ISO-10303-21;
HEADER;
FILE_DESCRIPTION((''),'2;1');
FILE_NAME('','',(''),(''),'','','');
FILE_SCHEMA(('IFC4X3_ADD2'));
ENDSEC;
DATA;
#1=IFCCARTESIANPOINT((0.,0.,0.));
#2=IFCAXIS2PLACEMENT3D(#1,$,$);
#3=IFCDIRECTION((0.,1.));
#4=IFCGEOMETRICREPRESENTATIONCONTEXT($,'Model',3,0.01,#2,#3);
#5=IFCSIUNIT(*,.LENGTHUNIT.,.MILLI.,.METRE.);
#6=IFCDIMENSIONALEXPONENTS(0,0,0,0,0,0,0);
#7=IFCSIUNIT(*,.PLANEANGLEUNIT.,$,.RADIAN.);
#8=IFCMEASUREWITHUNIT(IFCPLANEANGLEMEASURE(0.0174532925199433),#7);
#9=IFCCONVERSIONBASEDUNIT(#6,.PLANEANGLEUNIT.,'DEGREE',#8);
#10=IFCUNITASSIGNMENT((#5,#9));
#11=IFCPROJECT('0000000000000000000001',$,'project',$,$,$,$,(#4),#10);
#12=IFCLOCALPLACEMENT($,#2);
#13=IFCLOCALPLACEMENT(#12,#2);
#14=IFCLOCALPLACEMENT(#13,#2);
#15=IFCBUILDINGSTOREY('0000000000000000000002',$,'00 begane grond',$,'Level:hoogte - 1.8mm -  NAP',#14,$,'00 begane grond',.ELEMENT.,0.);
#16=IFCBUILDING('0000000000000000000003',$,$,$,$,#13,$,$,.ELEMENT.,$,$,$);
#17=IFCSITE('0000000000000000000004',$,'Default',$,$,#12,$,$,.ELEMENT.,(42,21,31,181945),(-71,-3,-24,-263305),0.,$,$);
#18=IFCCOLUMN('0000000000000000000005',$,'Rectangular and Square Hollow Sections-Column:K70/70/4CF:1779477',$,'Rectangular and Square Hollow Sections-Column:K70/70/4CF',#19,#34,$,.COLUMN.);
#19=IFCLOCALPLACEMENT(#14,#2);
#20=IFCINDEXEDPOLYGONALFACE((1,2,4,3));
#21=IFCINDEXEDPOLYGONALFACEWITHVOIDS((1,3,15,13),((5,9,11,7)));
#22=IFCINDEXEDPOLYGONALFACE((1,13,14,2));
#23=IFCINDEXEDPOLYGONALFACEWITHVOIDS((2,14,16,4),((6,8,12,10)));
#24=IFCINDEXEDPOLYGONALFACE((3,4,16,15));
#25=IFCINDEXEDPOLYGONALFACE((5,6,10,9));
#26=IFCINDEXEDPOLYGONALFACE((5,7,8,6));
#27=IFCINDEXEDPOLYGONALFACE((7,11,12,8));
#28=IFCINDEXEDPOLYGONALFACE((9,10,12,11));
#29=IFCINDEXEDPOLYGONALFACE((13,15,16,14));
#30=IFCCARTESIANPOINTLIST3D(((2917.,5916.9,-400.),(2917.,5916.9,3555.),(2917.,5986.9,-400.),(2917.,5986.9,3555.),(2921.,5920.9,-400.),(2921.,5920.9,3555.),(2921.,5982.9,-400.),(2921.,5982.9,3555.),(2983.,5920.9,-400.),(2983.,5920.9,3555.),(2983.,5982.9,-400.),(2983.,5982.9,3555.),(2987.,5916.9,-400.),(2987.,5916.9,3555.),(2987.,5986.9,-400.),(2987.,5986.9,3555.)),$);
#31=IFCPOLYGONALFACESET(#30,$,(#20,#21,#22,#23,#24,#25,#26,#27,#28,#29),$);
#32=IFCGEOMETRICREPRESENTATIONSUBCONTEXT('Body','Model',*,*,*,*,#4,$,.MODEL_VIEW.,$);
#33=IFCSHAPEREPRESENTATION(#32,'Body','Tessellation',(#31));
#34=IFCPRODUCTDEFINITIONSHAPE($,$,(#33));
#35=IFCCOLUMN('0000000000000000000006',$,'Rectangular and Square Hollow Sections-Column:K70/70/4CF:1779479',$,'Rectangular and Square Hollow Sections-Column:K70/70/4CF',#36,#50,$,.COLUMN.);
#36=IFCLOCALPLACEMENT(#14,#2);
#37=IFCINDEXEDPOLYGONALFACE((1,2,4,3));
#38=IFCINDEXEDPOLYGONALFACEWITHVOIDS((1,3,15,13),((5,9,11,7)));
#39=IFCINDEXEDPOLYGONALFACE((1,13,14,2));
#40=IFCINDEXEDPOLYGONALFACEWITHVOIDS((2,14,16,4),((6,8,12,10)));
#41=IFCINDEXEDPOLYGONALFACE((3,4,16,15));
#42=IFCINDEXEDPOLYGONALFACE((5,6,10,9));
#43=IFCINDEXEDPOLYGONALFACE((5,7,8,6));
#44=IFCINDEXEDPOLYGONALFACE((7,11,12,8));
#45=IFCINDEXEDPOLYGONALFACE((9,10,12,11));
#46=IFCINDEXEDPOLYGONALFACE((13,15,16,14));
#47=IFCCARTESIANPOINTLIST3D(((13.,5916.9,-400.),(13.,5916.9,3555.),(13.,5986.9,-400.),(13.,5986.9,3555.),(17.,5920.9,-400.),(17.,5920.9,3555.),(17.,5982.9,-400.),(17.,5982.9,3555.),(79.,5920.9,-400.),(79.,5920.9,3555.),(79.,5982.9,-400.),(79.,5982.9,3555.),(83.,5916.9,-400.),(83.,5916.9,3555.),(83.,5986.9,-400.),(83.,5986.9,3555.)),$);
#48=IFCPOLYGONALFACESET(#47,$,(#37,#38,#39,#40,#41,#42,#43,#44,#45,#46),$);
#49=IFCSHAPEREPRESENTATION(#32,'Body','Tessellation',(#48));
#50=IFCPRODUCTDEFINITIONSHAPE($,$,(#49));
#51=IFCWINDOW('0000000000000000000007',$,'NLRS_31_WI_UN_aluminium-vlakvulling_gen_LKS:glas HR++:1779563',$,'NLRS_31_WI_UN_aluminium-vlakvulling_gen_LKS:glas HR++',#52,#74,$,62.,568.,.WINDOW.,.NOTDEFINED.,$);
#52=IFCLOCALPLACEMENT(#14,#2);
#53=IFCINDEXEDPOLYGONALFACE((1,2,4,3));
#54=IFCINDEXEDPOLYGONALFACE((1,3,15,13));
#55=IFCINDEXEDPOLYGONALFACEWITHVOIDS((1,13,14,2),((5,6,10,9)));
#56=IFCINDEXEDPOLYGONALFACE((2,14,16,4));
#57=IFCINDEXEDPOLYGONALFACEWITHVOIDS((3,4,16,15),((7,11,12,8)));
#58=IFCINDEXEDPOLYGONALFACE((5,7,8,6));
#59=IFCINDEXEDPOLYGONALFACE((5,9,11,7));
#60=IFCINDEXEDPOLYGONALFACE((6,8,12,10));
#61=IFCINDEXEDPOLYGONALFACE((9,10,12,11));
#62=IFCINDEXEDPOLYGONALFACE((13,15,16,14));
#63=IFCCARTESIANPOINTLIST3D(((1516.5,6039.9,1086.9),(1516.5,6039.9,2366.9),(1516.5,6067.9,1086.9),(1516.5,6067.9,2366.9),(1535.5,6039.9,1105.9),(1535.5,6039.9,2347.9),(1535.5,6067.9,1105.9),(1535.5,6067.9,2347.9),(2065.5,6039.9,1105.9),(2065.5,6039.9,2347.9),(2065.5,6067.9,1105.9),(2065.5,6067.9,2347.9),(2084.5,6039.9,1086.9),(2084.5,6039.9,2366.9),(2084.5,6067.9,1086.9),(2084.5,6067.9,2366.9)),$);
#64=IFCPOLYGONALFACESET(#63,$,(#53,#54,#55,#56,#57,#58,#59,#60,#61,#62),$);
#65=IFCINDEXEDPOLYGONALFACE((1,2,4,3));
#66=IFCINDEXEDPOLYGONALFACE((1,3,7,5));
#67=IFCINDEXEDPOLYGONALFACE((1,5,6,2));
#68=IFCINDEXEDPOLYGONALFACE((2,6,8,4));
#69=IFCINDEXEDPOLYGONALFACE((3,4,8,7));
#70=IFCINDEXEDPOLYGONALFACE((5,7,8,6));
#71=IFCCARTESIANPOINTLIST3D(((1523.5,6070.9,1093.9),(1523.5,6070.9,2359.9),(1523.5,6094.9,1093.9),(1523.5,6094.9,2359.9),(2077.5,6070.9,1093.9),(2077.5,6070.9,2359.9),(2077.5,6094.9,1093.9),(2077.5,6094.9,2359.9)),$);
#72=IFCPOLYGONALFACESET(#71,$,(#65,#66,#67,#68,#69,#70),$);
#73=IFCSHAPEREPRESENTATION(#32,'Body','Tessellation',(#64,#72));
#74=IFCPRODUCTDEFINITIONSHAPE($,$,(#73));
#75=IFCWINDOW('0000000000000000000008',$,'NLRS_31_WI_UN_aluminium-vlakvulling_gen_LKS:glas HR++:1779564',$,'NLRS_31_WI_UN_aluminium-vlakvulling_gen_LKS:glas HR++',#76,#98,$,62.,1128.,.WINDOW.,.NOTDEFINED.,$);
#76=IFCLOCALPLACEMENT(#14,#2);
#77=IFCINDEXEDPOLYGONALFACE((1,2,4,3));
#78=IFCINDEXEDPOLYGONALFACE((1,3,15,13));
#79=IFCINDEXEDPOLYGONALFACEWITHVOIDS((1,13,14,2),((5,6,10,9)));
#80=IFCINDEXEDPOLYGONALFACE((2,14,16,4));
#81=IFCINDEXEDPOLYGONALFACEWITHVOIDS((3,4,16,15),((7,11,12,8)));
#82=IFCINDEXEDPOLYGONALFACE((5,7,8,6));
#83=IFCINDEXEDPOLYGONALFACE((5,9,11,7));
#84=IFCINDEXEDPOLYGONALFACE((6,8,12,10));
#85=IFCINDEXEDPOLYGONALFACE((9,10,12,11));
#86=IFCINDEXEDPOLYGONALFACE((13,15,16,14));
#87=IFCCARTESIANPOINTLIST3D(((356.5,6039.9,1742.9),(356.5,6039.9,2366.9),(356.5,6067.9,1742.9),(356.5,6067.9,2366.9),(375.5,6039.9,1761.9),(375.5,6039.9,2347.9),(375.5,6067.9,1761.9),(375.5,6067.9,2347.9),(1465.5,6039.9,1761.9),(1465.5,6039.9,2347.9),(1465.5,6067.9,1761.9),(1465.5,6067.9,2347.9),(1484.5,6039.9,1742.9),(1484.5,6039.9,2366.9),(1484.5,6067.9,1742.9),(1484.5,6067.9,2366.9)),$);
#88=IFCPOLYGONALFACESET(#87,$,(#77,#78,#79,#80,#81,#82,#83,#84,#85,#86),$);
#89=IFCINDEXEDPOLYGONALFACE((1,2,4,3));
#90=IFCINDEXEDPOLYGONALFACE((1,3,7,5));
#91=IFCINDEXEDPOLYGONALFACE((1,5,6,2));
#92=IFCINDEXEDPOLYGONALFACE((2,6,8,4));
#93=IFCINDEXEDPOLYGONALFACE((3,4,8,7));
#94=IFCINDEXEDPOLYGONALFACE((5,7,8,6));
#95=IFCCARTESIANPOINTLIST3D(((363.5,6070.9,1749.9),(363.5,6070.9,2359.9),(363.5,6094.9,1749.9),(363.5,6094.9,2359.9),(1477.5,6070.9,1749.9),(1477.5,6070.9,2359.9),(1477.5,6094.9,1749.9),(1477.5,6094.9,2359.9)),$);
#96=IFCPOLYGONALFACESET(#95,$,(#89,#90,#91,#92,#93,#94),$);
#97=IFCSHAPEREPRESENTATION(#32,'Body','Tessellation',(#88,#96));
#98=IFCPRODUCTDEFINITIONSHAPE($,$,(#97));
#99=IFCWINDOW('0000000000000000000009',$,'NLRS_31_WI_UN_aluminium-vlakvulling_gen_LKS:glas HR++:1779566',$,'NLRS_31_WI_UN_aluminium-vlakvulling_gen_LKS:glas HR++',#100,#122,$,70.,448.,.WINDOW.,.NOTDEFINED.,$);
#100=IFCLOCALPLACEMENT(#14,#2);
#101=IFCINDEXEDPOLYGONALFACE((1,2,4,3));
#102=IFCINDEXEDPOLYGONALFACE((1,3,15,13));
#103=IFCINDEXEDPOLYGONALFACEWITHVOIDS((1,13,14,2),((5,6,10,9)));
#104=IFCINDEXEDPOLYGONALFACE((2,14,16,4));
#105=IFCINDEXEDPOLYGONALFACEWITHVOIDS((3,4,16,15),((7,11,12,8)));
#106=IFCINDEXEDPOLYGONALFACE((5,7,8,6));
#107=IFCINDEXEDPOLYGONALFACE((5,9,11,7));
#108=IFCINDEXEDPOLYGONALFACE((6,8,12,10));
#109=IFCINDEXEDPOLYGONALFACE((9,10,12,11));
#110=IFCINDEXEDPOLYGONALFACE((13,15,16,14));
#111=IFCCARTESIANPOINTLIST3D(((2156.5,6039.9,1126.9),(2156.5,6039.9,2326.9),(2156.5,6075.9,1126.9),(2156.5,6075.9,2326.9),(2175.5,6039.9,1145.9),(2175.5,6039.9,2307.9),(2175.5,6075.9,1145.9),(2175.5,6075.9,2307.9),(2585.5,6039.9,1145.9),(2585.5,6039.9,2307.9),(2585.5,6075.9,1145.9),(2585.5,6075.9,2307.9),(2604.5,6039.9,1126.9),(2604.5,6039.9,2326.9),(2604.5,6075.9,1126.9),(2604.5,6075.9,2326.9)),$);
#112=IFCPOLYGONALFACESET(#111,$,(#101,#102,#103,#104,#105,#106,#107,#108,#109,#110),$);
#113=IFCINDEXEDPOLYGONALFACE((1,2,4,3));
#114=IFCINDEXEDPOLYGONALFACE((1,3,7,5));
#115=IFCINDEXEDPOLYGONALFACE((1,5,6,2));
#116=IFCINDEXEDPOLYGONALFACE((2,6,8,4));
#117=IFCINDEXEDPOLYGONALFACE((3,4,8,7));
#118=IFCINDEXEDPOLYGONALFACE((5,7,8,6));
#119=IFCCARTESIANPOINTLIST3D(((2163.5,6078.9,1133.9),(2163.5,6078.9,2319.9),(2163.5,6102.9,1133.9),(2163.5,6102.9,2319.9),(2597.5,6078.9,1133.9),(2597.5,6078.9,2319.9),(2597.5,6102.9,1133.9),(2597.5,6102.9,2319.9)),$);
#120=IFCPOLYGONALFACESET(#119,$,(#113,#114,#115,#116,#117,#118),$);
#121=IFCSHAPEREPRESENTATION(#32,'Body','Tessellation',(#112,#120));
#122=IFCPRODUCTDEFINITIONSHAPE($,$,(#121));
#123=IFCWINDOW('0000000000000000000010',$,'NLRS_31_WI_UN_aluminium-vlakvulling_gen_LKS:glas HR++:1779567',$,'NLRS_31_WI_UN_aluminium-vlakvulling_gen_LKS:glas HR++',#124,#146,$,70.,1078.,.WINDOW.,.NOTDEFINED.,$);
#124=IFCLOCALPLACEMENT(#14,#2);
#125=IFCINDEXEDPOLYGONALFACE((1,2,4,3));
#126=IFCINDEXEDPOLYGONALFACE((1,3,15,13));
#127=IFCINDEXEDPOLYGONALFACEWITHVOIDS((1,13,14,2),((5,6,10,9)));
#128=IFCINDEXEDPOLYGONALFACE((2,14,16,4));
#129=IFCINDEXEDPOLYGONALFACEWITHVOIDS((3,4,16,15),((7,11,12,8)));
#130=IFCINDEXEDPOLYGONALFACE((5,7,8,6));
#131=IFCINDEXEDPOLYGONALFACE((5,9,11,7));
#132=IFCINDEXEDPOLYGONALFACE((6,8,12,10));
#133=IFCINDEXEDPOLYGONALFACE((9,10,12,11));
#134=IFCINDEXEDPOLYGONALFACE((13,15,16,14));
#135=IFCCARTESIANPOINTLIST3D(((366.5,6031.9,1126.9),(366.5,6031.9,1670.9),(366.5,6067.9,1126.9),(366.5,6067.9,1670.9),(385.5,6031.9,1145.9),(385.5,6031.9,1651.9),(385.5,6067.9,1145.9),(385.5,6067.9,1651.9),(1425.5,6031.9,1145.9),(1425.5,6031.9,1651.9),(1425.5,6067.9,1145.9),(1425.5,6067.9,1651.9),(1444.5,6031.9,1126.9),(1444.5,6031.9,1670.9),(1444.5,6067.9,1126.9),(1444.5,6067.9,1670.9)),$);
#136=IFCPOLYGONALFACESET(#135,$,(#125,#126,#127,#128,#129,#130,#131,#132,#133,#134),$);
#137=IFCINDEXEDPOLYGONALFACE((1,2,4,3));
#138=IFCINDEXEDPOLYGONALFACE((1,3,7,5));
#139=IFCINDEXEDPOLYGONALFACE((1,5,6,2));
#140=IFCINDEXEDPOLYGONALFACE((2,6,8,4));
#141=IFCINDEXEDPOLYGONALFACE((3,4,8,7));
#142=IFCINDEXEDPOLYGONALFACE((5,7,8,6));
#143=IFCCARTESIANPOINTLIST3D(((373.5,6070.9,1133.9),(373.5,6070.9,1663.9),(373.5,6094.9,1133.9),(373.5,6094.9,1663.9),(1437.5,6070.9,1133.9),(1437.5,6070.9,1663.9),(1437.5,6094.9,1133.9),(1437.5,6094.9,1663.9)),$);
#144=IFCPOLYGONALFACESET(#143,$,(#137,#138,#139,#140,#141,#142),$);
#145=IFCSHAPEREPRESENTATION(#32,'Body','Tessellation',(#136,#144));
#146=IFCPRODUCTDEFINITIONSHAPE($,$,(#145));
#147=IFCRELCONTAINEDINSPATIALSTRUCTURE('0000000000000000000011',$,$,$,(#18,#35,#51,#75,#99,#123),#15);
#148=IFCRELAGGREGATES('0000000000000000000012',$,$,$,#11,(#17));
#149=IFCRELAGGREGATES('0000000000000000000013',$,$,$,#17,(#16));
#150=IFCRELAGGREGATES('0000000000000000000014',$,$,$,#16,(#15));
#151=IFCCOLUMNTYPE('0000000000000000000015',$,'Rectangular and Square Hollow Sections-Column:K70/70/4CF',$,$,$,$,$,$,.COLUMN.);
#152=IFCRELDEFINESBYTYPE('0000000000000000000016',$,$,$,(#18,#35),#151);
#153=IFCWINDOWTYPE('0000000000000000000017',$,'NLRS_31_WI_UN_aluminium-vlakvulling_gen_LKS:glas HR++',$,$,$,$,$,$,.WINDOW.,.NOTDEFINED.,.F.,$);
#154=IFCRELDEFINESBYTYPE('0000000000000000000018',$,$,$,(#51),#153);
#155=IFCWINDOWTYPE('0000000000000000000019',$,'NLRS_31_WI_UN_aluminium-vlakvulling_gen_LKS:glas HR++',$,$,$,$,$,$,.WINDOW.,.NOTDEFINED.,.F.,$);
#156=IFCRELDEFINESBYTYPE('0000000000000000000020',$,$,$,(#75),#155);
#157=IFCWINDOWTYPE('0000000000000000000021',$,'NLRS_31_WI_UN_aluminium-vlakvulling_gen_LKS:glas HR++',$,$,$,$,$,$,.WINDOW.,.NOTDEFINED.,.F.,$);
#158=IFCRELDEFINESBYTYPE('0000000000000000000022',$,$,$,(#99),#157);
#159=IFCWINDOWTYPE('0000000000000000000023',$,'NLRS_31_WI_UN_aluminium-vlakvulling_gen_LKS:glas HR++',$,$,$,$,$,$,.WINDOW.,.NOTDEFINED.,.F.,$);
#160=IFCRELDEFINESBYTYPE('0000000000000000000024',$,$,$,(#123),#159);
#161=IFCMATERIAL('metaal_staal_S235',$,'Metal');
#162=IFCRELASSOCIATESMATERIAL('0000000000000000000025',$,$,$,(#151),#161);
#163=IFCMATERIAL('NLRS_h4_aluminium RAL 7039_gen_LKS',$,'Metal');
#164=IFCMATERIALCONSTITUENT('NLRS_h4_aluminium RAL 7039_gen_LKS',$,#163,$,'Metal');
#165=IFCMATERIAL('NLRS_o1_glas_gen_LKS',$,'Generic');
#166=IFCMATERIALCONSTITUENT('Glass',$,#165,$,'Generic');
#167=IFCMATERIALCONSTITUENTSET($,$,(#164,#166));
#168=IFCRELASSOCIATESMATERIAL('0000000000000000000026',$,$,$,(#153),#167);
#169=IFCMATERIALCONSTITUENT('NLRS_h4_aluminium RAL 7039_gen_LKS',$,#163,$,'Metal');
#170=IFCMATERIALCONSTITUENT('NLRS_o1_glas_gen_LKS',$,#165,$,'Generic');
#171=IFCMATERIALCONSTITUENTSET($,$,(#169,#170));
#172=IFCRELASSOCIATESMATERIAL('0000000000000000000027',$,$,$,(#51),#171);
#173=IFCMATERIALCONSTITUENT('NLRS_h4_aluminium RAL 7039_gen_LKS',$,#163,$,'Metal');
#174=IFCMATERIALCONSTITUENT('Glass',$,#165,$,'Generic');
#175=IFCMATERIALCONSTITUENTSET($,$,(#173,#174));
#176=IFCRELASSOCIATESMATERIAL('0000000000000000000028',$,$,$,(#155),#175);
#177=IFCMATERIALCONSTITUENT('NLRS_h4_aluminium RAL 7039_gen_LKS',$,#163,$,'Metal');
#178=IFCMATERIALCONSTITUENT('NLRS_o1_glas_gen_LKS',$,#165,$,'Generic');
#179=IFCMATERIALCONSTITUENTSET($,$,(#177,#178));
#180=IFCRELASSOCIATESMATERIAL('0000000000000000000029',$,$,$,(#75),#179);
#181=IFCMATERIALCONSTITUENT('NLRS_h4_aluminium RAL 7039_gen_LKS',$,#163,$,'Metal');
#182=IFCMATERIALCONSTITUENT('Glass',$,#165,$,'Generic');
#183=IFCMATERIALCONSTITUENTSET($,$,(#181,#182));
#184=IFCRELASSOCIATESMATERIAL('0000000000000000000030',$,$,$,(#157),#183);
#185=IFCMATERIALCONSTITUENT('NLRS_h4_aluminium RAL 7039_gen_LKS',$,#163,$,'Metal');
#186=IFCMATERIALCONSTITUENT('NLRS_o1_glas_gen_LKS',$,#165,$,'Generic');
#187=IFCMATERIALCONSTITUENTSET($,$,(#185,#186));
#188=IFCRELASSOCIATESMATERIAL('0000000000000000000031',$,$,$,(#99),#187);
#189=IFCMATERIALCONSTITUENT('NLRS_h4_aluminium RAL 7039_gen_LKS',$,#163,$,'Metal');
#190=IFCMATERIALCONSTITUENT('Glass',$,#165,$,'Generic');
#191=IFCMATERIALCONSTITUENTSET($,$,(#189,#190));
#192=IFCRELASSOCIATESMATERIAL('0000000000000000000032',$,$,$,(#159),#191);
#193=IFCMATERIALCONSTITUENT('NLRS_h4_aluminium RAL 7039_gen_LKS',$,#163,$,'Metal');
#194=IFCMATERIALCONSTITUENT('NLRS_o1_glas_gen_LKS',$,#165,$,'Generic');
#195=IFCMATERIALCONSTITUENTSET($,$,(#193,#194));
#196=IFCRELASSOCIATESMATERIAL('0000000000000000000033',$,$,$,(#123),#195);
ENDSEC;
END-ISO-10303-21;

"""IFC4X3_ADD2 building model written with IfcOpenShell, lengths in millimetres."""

from ifc_helpers import new_model, entity, si_unit, converted_unit, direction, frame, frame_2d, origin, origin_2d_with_axis, place, context, subcontext, project, spatial, polyline, rectangle, outline, extrude, source, transform, mapped, material, constituent, constituent_set, material_profile, profile_set, type_object, type_shapes, element, save


model = new_model("IFC4X3_ADD2")

# Units and contexts
model_context = context("Model", 3, precision=0.01, world=origin(), true_north=direction((0.0, 1.0)))
body_context = subcontext(model_context, "Body", "Model", "MODEL_VIEW")
ifc_project = project(units=[si_unit("LENGTHUNIT", "METRE", prefix="MILLI"), converted_unit("PLANEANGLEUNIT", "DEGREE", entity("IfcPlaneAngleMeasure", 0.0174532925199433), si_unit("PLANEANGLEUNIT", "RADIAN"), dimensions=[0, 0, 0, 0, 0, 0, 0])], contexts=[model_context])

# Site, building, storey
site_placement = place(None, origin())
site = spatial("IfcSite", under=ifc_project, at=site_placement, Name="Default", CompositionType="ELEMENT", RefLatitude=(42, 21, 31, 181945), RefLongitude=(-71, -3, -24, -263305), RefElevation=0.0)
building_placement = place(site_placement, origin())
building = spatial("IfcBuilding", under=site, at=building_placement, CompositionType="ELEMENT")
storey_placement = place(building_placement, origin())
storey = spatial("IfcBuildingStorey", under=building, at=storey_placement, Name="00 begane grond", ObjectType="Level:hoogte - 1.8mm -  NAP", LongName="00 begane grond", CompositionType="ELEMENT", Elevation=0.0)

# Columns
ifc_material_1 = material(Name="metaal_staal_S235", Category="Metal")
ifc_material_profile_1 = material_profile(ifc_material_1, outline(polyline([(-35.0, -35.0), (35.0, -35.0), (35.0, 35.0), (-35.0, 35.0), (-35.0, -35.0)]), holes=[polyline([(-31.0, -31.0), (-31.0, 31.0), (31.0, 31.0), (31.0, -31.0), (-31.0, -31.0)])]), Name="K70/70/4CF")
ifc_profile_set_1 = profile_set([ifc_material_profile_1], Name="K70/70/4CF")
column_type = type_object("IfcColumnType", Name="Rectangular and Square Hollow Sections-Column:K70/70/4CF", PredefinedType="COLUMN", material=ifc_profile_set_1)
shared_shape_1 = source(origin(), body_context, "Body", "SweptSolid", [
    extrude(outline(polyline([(-35.0, -35.0), (35.0, -35.0), (35.0, 35.0), (-35.0, 35.0), (-35.0, -35.0)]), holes=[polyline([(-31.0, -31.0), (-31.0, 31.0), (31.0, 31.0), (31.0, -31.0), (-31.0, -31.0)])]), frame((0.0, 0.0, -400.0), z_axis=(0.0, 0.0, 1.0), x_axis=(0.0, 1.0, 0.0)), (0.0, 0.0, 1.0), 3955.0),
])
type_shapes(column_type, [shared_shape_1])
for number, where, z_axis, x_axis, name in (
    (1, (2952.0, 5951.9, 0.0), (0.0, 0.0, 1.0), (0.0, 1.0, 0.0), "Rectangular and Square Hollow Sections-Column:K70/70/4CF:1779477"),
    (2, (48.0, 5951.9, 0.0), (0.0, 0.0, 1.0), (0.0, 1.0, 0.0), "Rectangular and Square Hollow Sections-Column:K70/70/4CF:1779479"),
):
    element("IfcColumn", number, at=place(storey_placement, frame(where, z_axis=z_axis, x_axis=x_axis)), inside=storey, type_object=column_type, Name=name, ObjectType="Rectangular and Square Hollow Sections-Column:K70/70/4CF", PredefinedType="COLUMN", context=body_context, shape_type="MappedRepresentation", body=[
        mapped(shared_shape_1, transform((0.0, 0.0, 0.0), scale=1.0)),
    ])

# Windows
ifc_material_2 = material(Name="NLRS_h4_aluminium RAL 7039_gen_LKS", Category="Metal")
ifc_constituent_1 = constituent(ifc_material_2, Name="NLRS_h4_aluminium RAL 7039_gen_LKS", Category="Metal")
ifc_material_3 = material(Name="NLRS_o1_glas_gen_LKS", Category="Generic")
ifc_constituent_2 = constituent(ifc_material_3, Name="NLRS_o1_glas_gen_LKS", Category="Generic")
ifc_constituent_set_1 = constituent_set(constituents=[ifc_constituent_1, ifc_constituent_2])
ifc_constituent_3 = constituent(ifc_material_2, Name="NLRS_h4_aluminium RAL 7039_gen_LKS", Category="Metal")
ifc_constituent_4 = constituent(ifc_material_3, Name="Glass", Category="Generic")
ifc_constituent_set_2 = constituent_set(constituents=[ifc_constituent_3, ifc_constituent_4])
window_type_1 = type_object("IfcWindowType", Name="NLRS_31_WI_UN_aluminium-vlakvulling_gen_LKS:glas HR++", ParameterTakesPrecedence=False, PartitioningType="NOTDEFINED", PredefinedType="WINDOW", material=ifc_constituent_set_2)
shared_shape_2 = source(origin(), body_context, "Body", "SweptSolid", [
    extrude(outline(polyline([(-640.0, -284.0), (640.0, -284.0), (640.0, 284.0), (-640.0, 284.0), (-640.0, -284.0)]), holes=[polyline([(621.0, -265.0), (-621.0, -265.0), (-621.0, 265.0), (621.0, 265.0), (621.0, -265.0)])]), frame((0.0, 34.0, 640.0), z_axis=(0.0, 1.0, 0.0), x_axis=(0.0, 0.0, -1.0)), (0.0, 0.0, 1.0), 28.0),
    extrude(rectangle(XDim=24.0, YDim=554.0, at=frame_2d((0.0, 0.0), x_axis=(1.0, 0.0))), frame((0.0, 19.0, 7.0), z_axis=(0.0, 0.0, 1.0), x_axis=(0.0, -1.0, 0.0)), (0.0, 0.0, 1.0), 1266.0),
])
type_shapes(window_type_1, [shared_shape_2])
window_1_placement = place(storey_placement, frame((1800.5, 6101.9, 1086.9), z_axis=(0.0, 0.0, 1.0), x_axis=(-1.0, 0.0, 0.0)))
element("IfcWindow", 3, at=window_1_placement, inside=storey, type_object=window_type_1, material=ifc_constituent_set_1, Name="NLRS_31_WI_UN_aluminium-vlakvulling_gen_LKS:glas HR++:1779563", ObjectType="NLRS_31_WI_UN_aluminium-vlakvulling_gen_LKS:glas HR++", OverallHeight=62.0, OverallWidth=568.0, PartitioningType="NOTDEFINED", PredefinedType="WINDOW", context=body_context, shape_type="MappedRepresentation", body=[
    mapped(shared_shape_2, transform((0.0, 0.0, 0.0), scale=1.0)),
])
ifc_constituent_5 = constituent(ifc_material_2, Name="NLRS_h4_aluminium RAL 7039_gen_LKS", Category="Metal")
ifc_constituent_6 = constituent(ifc_material_3, Name="NLRS_o1_glas_gen_LKS", Category="Generic")
ifc_constituent_set_3 = constituent_set(constituents=[ifc_constituent_5, ifc_constituent_6])
ifc_constituent_7 = constituent(ifc_material_2, Name="NLRS_h4_aluminium RAL 7039_gen_LKS", Category="Metal")
ifc_constituent_8 = constituent(ifc_material_3, Name="Glass", Category="Generic")
ifc_constituent_set_4 = constituent_set(constituents=[ifc_constituent_7, ifc_constituent_8])
window_type_2 = type_object("IfcWindowType", Name="NLRS_31_WI_UN_aluminium-vlakvulling_gen_LKS:glas HR++", ParameterTakesPrecedence=False, PartitioningType="NOTDEFINED", PredefinedType="WINDOW", material=ifc_constituent_set_4)
shared_shape_3 = source(origin(), body_context, "Body", "SweptSolid", [
    extrude(outline(polyline([(-312.0, -564.0), (312.0, -564.0), (312.0, 564.0), (-312.0, 564.0), (-312.0, -564.0)]), holes=[polyline([(293.0, -545.0), (-293.0, -545.0), (-293.0, 545.0), (293.0, 545.0), (293.0, -545.0)])]), frame((0.0, 34.0, 312.0), z_axis=(0.0, 1.0, 0.0), x_axis=(0.0, 0.0, -1.0)), (0.0, 0.0, 1.0), 28.0),
    extrude(rectangle(XDim=24.0, YDim=1114.0, at=frame_2d((0.0, 0.0), x_axis=(1.0, 0.0))), frame((0.0, 19.0, 7.0), z_axis=(0.0, 0.0, 1.0), x_axis=(0.0, -1.0, 0.0)), (0.0, 0.0, 1.0), 610.0),
])
type_shapes(window_type_2, [shared_shape_3])
window_2_placement = place(storey_placement, frame((920.5, 6101.9, 1742.9), z_axis=(0.0, 0.0, 1.0), x_axis=(-1.0, 0.0, 0.0)))
element("IfcWindow", 4, at=window_2_placement, inside=storey, type_object=window_type_2, material=ifc_constituent_set_3, Name="NLRS_31_WI_UN_aluminium-vlakvulling_gen_LKS:glas HR++:1779564", ObjectType="NLRS_31_WI_UN_aluminium-vlakvulling_gen_LKS:glas HR++", OverallHeight=62.0, OverallWidth=1128.0, PartitioningType="NOTDEFINED", PredefinedType="WINDOW", context=body_context, shape_type="MappedRepresentation", body=[
    mapped(shared_shape_3, transform((0.0, 0.0, 0.0), scale=1.0)),
])
ifc_constituent_9 = constituent(ifc_material_2, Name="NLRS_h4_aluminium RAL 7039_gen_LKS", Category="Metal")
ifc_constituent_10 = constituent(ifc_material_3, Name="NLRS_o1_glas_gen_LKS", Category="Generic")
ifc_constituent_set_5 = constituent_set(constituents=[ifc_constituent_9, ifc_constituent_10])
ifc_constituent_11 = constituent(ifc_material_2, Name="NLRS_h4_aluminium RAL 7039_gen_LKS", Category="Metal")
ifc_constituent_12 = constituent(ifc_material_3, Name="Glass", Category="Generic")
ifc_constituent_set_6 = constituent_set(constituents=[ifc_constituent_11, ifc_constituent_12])
window_type_3 = type_object("IfcWindowType", Name="NLRS_31_WI_UN_aluminium-vlakvulling_gen_LKS:glas HR++", ParameterTakesPrecedence=False, PartitioningType="NOTDEFINED", PredefinedType="WINDOW", material=ifc_constituent_set_6)
shared_shape_4 = source(origin(), body_context, "Body", "SweptSolid", [
    extrude(outline(polyline([(-600.0, -224.0), (600.0, -224.0), (600.0, 224.0), (-600.0, 224.0), (-600.0, -224.0)]), holes=[polyline([(581.0, -205.0), (-581.0, -205.0), (-581.0, 205.0), (581.0, 205.0), (581.0, -205.0)])]), frame((0.0, 34.0, 600.0), z_axis=(0.0, 1.0, 0.0), x_axis=(0.0, 0.0, -1.0)), (0.0, 0.0, 1.0), 36.0),
    extrude(rectangle(XDim=24.0, YDim=434.0, at=origin_2d_with_axis()), frame((0.0, 19.0, 7.0), z_axis=(0.0, 0.0, 1.0), x_axis=(0.0, -1.0, 0.0)), (0.0, 0.0, 1.0), 1186.0),
])
type_shapes(window_type_3, [shared_shape_4])
window_3_placement = place(storey_placement, frame((2380.5, 6109.9, 1126.9), z_axis=(0.0, 0.0, 1.0), x_axis=(-1.0, 0.0, 0.0)))
element("IfcWindow", 5, at=window_3_placement, inside=storey, type_object=window_type_3, material=ifc_constituent_set_5, Name="NLRS_31_WI_UN_aluminium-vlakvulling_gen_LKS:glas HR++:1779566", ObjectType="NLRS_31_WI_UN_aluminium-vlakvulling_gen_LKS:glas HR++", OverallHeight=70.0, OverallWidth=448.0, PartitioningType="NOTDEFINED", PredefinedType="WINDOW", context=body_context, shape_type="MappedRepresentation", body=[
    mapped(shared_shape_4, transform((0.0, 0.0, 0.0), scale=1.0)),
])
ifc_constituent_13 = constituent(ifc_material_2, Name="NLRS_h4_aluminium RAL 7039_gen_LKS", Category="Metal")
ifc_constituent_14 = constituent(ifc_material_3, Name="NLRS_o1_glas_gen_LKS", Category="Generic")
ifc_constituent_set_7 = constituent_set(constituents=[ifc_constituent_13, ifc_constituent_14])
ifc_constituent_15 = constituent(ifc_material_2, Name="NLRS_h4_aluminium RAL 7039_gen_LKS", Category="Metal")
ifc_constituent_16 = constituent(ifc_material_3, Name="Glass", Category="Generic")
ifc_constituent_set_8 = constituent_set(constituents=[ifc_constituent_15, ifc_constituent_16])
window_type_4 = type_object("IfcWindowType", Name="NLRS_31_WI_UN_aluminium-vlakvulling_gen_LKS:glas HR++", ParameterTakesPrecedence=False, PartitioningType="NOTDEFINED", PredefinedType="WINDOW", material=ifc_constituent_set_8)
shared_shape_5 = source(origin(), body_context, "Body", "SweptSolid", [
    extrude(outline(polyline([(-272.0, -539.0), (272.0, -539.0), (272.0, 539.0), (-272.0, 539.0), (-272.0, -539.0)]), holes=[polyline([(253.0, -520.0), (-253.0, -520.0), (-253.0, 520.0), (253.0, 520.0), (253.0, -520.0)])]), frame((0.0, 34.0, 272.0), z_axis=(0.0, 1.0, 0.0), x_axis=(0.0, 0.0, -1.0)), (0.0, 0.0, 1.0), 36.0),
    extrude(rectangle(XDim=24.0, YDim=1064.0, at=frame_2d((0.0, 0.0), x_axis=(1.0, 0.0))), frame((0.0, 19.0, 7.0), z_axis=(0.0, 0.0, 1.0), x_axis=(0.0, -1.0, 0.0)), (0.0, 0.0, 1.0), 530.0),
])
type_shapes(window_type_4, [shared_shape_5])
window_4_placement = place(storey_placement, frame((905.5, 6101.9, 1126.9), z_axis=(0.0, 0.0, 1.0), x_axis=(-1.0, 0.0, 0.0)))
element("IfcWindow", 6, at=window_4_placement, inside=storey, type_object=window_type_4, material=ifc_constituent_set_7, Name="NLRS_31_WI_UN_aluminium-vlakvulling_gen_LKS:glas HR++:1779567", ObjectType="NLRS_31_WI_UN_aluminium-vlakvulling_gen_LKS:glas HR++", OverallHeight=70.0, OverallWidth=1078.0, PartitioningType="NOTDEFINED", PredefinedType="WINDOW", context=body_context, shape_type="MappedRepresentation", body=[
    mapped(shared_shape_5, transform((0.0, 0.0, 0.0), scale=1.0)),
])

save(model, "model.ifc")
